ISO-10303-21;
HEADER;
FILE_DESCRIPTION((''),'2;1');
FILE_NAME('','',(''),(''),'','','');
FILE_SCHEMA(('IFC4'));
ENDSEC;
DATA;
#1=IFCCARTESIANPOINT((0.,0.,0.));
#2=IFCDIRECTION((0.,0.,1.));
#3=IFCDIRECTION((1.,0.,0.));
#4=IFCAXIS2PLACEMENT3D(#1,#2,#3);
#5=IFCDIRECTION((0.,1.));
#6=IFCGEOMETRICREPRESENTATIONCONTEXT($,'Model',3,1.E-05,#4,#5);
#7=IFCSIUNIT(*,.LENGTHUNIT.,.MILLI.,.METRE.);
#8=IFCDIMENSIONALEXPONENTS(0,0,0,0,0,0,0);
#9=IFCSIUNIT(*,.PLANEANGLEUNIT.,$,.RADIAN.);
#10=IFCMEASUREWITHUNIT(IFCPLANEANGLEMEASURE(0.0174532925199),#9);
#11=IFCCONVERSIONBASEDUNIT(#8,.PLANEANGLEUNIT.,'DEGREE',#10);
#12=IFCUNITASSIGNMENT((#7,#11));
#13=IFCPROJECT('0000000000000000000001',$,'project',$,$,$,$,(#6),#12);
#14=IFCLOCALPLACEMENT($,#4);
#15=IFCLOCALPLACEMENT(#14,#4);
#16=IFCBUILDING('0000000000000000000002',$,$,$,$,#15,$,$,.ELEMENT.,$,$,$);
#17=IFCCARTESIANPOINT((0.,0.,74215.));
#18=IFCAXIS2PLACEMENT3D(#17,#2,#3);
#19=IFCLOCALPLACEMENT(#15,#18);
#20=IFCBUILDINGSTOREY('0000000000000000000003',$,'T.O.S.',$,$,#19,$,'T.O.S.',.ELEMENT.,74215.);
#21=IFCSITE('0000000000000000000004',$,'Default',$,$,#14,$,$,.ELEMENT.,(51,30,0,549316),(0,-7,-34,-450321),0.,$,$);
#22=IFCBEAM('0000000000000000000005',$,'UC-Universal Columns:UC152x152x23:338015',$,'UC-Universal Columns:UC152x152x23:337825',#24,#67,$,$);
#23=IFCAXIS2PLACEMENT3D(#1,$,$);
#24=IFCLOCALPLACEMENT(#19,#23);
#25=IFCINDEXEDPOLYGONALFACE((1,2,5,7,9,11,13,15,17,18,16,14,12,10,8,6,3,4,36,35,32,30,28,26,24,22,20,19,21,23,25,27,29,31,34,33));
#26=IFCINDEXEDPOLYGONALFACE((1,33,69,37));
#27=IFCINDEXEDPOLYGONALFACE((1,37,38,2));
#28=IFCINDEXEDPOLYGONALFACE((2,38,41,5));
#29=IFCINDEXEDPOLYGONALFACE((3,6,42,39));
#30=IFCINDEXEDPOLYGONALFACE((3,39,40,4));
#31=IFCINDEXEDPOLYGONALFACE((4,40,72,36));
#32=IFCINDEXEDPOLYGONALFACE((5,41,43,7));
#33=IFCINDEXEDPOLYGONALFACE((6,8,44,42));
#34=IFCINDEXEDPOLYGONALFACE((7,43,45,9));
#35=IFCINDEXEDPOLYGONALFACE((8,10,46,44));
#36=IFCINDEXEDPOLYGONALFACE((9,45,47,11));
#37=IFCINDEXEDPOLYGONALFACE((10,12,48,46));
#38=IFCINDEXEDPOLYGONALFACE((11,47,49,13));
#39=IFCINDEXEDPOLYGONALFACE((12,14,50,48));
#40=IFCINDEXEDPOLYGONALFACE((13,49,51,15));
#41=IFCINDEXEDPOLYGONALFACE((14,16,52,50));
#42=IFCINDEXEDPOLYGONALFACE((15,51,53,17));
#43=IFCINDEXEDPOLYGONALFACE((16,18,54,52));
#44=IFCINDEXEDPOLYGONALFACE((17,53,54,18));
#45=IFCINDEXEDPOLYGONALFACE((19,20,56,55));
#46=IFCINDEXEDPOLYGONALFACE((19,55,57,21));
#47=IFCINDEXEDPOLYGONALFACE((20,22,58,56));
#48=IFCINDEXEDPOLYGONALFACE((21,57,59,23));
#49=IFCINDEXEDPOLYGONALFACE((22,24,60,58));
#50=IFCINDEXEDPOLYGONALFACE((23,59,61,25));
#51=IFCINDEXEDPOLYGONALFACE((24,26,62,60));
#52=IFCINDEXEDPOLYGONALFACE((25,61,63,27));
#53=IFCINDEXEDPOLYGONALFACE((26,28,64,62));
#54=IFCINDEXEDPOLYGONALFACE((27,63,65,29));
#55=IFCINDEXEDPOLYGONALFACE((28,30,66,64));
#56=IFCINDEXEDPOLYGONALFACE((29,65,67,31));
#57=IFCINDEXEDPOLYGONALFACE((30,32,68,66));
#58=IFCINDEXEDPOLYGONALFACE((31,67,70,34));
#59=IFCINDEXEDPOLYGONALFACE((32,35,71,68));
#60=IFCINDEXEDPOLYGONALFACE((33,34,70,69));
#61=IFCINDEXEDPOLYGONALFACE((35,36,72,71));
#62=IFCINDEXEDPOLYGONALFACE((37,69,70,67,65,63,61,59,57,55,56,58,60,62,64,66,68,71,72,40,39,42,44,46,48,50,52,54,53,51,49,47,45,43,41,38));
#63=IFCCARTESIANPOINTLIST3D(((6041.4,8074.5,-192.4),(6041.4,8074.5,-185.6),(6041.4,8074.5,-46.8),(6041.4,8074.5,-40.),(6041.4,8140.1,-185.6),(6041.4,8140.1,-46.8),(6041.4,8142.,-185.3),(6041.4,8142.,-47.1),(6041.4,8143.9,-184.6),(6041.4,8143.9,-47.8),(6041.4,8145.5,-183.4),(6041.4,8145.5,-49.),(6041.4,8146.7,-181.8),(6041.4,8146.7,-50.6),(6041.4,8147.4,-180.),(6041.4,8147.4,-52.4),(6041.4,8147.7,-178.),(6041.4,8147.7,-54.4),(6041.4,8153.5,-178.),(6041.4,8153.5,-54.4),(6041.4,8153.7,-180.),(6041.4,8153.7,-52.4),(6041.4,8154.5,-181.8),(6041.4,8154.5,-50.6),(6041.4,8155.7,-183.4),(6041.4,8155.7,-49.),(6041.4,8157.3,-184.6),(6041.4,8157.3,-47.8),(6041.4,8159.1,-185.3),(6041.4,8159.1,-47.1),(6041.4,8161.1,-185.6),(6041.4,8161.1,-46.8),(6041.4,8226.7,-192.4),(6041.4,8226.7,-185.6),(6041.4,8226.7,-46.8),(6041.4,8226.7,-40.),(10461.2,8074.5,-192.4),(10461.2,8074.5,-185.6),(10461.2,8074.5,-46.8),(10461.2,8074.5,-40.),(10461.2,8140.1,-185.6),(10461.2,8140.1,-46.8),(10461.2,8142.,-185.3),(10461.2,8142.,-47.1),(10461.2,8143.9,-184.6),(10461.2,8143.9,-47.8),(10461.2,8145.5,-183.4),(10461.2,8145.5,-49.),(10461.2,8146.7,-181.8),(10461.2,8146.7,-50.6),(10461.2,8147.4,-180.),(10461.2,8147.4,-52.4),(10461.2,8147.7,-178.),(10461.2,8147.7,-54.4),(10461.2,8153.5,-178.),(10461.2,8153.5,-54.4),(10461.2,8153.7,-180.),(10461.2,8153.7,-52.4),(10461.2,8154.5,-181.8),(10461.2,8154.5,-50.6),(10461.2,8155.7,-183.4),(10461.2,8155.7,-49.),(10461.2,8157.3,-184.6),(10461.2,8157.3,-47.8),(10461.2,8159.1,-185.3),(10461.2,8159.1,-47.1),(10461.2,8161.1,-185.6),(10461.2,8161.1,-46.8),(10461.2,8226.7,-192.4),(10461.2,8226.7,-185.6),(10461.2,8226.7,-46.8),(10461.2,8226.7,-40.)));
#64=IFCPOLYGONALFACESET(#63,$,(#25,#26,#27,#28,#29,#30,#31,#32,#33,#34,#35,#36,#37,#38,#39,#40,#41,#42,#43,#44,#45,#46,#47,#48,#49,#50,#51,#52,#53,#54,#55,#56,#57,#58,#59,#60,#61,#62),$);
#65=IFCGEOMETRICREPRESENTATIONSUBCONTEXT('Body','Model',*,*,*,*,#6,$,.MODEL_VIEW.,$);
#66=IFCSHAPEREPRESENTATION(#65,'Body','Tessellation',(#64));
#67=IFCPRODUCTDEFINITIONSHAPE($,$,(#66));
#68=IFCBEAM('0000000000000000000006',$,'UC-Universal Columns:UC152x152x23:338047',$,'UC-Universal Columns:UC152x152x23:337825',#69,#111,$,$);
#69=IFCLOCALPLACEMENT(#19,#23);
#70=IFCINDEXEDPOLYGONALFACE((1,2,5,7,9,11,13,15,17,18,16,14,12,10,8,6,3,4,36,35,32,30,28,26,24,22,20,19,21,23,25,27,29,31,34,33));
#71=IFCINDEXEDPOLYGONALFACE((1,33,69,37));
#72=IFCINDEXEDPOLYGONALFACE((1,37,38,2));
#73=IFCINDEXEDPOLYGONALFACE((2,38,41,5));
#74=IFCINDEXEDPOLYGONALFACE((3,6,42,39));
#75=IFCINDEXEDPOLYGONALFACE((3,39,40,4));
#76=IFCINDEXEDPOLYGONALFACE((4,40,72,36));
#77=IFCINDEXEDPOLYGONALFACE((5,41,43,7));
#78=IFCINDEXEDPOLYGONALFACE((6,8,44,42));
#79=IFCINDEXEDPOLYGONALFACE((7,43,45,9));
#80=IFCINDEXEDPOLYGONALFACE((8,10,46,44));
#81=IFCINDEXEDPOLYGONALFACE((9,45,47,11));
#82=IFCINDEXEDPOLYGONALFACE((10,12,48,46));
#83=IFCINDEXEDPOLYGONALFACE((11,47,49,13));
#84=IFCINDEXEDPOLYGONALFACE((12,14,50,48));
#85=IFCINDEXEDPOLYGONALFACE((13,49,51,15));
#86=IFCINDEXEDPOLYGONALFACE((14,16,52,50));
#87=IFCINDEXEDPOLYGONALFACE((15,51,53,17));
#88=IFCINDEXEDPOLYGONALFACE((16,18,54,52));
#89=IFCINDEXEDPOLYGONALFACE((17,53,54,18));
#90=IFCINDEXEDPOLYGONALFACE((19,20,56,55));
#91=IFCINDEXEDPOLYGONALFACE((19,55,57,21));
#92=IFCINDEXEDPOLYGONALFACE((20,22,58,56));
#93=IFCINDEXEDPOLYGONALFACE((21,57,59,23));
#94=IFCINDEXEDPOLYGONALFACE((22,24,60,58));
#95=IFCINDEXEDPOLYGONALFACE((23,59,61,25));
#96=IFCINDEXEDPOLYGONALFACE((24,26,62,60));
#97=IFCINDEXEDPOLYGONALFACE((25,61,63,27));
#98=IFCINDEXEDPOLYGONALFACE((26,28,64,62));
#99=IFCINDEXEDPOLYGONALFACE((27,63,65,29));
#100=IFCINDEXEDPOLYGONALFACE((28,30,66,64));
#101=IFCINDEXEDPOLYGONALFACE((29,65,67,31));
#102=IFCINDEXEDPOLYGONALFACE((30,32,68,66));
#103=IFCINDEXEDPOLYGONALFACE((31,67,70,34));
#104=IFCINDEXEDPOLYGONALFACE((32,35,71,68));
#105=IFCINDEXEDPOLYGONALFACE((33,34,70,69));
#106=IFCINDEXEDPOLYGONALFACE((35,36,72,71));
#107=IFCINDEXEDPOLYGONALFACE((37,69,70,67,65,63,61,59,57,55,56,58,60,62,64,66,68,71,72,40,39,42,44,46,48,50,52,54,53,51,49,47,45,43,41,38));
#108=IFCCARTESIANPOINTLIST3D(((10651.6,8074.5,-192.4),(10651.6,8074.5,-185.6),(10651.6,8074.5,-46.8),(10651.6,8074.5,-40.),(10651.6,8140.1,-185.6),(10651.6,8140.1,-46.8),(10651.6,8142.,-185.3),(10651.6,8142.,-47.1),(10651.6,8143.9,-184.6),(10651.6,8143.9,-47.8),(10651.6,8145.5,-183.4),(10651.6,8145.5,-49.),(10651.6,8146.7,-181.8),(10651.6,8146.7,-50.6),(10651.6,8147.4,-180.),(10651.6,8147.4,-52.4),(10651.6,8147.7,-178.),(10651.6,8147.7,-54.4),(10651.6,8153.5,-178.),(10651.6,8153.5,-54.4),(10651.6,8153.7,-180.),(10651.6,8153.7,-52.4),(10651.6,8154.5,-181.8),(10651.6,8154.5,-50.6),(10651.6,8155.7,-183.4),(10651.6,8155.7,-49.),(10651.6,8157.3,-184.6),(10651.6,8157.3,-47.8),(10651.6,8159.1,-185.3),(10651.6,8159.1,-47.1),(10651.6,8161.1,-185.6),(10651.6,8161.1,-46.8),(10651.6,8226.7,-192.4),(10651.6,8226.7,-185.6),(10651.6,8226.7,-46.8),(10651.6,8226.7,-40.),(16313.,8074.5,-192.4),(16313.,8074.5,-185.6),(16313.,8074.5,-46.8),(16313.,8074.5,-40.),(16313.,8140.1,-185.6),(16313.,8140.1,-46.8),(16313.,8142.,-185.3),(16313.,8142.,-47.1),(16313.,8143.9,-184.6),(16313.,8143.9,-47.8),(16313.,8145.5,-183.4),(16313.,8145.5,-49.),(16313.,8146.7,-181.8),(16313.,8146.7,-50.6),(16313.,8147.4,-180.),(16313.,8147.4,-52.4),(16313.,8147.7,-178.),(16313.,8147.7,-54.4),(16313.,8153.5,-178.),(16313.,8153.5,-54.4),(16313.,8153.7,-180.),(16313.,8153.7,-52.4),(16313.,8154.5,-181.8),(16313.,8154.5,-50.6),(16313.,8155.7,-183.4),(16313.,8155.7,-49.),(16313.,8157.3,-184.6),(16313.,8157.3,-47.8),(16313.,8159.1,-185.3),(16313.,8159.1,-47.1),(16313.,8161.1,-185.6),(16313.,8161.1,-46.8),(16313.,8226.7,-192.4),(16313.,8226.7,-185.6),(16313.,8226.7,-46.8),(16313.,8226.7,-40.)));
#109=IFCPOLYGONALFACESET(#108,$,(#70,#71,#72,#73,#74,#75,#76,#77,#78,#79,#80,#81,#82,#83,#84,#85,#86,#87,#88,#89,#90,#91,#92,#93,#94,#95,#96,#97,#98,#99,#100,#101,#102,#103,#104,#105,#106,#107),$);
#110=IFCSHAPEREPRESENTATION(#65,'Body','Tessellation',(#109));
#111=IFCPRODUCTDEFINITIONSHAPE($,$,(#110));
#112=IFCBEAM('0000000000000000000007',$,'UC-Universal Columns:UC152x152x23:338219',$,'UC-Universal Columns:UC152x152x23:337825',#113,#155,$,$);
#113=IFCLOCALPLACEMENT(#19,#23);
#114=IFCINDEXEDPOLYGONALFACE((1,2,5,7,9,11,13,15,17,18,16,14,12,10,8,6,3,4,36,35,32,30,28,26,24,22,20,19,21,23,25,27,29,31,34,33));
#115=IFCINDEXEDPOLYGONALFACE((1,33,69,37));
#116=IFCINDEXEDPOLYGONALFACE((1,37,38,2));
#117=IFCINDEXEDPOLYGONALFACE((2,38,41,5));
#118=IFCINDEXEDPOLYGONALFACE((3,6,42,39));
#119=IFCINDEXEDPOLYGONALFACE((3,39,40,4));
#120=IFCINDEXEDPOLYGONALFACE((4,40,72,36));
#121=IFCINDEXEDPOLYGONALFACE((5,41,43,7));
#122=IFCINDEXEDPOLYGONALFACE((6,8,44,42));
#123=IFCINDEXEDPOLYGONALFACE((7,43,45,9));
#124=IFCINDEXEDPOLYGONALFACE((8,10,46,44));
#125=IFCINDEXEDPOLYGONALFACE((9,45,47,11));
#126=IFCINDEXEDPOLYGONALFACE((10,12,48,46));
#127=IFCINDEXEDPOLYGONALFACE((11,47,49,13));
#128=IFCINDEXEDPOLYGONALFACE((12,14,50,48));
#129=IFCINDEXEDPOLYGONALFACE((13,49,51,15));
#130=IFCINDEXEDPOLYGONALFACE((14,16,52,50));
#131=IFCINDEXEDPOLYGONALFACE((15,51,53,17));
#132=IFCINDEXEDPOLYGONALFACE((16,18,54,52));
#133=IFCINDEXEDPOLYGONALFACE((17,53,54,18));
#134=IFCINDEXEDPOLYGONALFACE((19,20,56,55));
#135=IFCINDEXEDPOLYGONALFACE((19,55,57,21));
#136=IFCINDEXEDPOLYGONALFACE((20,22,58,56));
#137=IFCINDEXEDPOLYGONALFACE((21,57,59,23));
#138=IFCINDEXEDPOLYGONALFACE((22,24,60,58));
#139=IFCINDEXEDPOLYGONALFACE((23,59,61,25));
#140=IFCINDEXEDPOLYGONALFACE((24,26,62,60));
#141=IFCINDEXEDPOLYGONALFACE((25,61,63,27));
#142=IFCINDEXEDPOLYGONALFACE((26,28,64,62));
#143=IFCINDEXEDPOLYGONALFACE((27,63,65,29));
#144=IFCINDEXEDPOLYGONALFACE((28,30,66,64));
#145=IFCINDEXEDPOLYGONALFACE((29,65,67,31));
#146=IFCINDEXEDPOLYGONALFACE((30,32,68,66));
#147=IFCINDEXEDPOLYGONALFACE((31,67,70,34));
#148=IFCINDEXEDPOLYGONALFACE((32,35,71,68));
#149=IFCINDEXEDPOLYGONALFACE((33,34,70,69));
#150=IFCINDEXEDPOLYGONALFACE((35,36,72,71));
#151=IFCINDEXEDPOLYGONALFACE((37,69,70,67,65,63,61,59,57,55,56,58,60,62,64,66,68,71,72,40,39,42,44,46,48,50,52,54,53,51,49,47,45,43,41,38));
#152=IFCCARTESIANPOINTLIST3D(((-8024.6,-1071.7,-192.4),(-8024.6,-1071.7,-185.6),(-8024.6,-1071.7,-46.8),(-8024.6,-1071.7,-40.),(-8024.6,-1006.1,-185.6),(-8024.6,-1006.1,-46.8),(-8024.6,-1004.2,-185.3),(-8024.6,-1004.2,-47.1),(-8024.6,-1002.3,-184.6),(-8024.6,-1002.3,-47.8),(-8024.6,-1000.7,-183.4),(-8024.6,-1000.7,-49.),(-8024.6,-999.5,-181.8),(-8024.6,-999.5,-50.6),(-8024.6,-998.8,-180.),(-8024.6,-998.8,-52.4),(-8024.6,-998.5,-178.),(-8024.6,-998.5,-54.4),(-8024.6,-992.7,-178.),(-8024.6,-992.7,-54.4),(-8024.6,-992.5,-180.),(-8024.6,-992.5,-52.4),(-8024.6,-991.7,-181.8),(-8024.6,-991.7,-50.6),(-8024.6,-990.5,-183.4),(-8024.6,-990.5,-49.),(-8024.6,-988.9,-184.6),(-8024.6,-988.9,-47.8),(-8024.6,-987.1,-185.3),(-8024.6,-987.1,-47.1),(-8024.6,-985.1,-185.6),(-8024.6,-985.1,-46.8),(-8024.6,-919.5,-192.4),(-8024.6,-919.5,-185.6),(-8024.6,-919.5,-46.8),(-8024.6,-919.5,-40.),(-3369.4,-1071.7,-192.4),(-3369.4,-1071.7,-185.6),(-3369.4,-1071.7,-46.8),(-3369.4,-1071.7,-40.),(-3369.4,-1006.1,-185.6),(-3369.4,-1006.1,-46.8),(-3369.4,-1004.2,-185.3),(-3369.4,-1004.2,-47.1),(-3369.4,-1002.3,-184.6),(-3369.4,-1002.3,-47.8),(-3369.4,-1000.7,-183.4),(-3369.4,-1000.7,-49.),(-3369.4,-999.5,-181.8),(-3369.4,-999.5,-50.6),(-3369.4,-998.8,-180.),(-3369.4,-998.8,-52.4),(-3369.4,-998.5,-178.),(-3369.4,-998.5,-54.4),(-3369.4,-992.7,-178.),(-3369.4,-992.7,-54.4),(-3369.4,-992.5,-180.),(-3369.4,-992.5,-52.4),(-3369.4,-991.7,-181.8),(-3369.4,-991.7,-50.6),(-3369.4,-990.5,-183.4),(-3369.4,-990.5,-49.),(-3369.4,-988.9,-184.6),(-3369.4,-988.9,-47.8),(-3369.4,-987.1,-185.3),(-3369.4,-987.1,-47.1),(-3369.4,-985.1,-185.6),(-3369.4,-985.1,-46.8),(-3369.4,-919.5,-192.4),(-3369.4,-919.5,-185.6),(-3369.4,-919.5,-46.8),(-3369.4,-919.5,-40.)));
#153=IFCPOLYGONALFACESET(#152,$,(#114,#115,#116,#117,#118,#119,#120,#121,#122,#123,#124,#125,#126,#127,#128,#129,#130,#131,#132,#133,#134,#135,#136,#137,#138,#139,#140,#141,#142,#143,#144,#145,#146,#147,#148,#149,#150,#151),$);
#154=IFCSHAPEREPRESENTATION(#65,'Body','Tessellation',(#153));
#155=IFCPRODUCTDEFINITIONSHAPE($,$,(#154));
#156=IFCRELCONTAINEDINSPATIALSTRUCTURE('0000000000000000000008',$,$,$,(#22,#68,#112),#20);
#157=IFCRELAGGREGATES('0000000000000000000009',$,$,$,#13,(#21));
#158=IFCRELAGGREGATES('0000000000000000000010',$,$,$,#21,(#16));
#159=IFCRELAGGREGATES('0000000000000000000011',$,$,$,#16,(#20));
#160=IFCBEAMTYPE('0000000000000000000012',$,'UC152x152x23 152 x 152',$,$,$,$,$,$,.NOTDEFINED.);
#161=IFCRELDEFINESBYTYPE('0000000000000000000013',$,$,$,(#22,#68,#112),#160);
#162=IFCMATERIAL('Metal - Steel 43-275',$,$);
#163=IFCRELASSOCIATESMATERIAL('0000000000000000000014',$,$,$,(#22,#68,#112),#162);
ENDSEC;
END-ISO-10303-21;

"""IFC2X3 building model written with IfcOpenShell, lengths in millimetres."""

from ifc_helpers import new_model, entity, si_unit, converted_unit, point, direction, frame, frame_2d, origin_with_axes, place, context, subcontext, project, spatial, polyline, circle_curve, parameter, trimmed, segment, composite_curve, outline, extrude, material, type_object, element, save


model = new_model("IFC2X3")

# Units and contexts
model_context = context("Model", 3, precision=1e-05, world=origin_with_axes(), true_north=direction((0.0, 1.0)))
body_context = subcontext(model_context, "Body", "Model", "MODEL_VIEW")
ifc_project = project(units=[si_unit("LENGTHUNIT", "METRE", prefix="MILLI"), converted_unit("PLANEANGLEUNIT", "DEGREE", entity("IfcPlaneAngleMeasure", 0.0174532925199), si_unit("PLANEANGLEUNIT", "RADIAN"), dimensions=[0, 0, 0, 0, 0, 0, 0])], contexts=[model_context])

# Site, building, storey
site_placement = place(None, origin_with_axes())
site = spatial("IfcSite", under=ifc_project, at=site_placement, Name="Default", CompositionType="ELEMENT", RefLatitude=(51, 30, 0, 549316), RefLongitude=(0, -7, -34, -450321), RefElevation=0.0)
building_placement = place(site_placement, origin_with_axes())
building = spatial("IfcBuilding", under=site, at=building_placement, CompositionType="ELEMENT")
storey_placement = place(building_placement, frame((0.0, 0.0, 74215.0), z_axis=(0.0, 0.0, 1.0), x_axis=(1.0, 0.0, 0.0)))
storey = spatial("IfcBuildingStorey", under=building, at=storey_placement, Name="T.O.S.", LongName="T.O.S.", CompositionType="ELEMENT", Elevation=74215.0)

# Beams
ifc_material = material(Name="Metal - Steel 43-275")
beam_type_1 = type_object("IfcBeamType", Name="UC152x152x23 152 x 152", PredefinedType="NOTDEFINED")
beam_1_placement = place(storey_placement, frame((10461.2, 8150.6, -116.2), z_axis=(0.0, 0.0, 1.0), x_axis=(0.0, 1.0, 0.0)))
element("IfcBeam", 1, at=beam_1_placement, inside=storey, type_object=beam_type_1, material=ifc_material, Name="UC-Universal Columns:UC152x152x23:338015", ObjectType="UC-Universal Columns:UC152x152x23:337825", context=body_context, shape_type="SweptSolid", body=[
    extrude(outline(composite_curve([segment(polyline([(76.2, 76.1), (69.4, 76.1), (69.4, 10.5)]), True, "CONTINUOUS"), segment(trimmed(circle_curve(frame_2d((61.8, 10.5), x_axis=(0.0, -1.0)), 7.6), [point((69.4, 10.5)), parameter(90.0)], [point((61.8, 2.9)), parameter(0.0)], False, "CARTESIAN"), True, "CONTINUOUS"), segment(polyline([(61.8, 2.9), (-61.8, 2.9)]), True, "CONTINUOUS"), segment(trimmed(circle_curve(frame_2d((-61.8, 10.5), x_axis=(-1.0, 0.0)), 7.6), [point((-61.8, 2.9)), parameter(90.0)], [point((-69.4, 10.5)), parameter(0.0)], False, "CARTESIAN"), True, "CONTINUOUS"), segment(polyline([(-69.4, 10.5), (-69.4, 76.1), (-76.2, 76.1), (-76.2, -76.1), (-69.4, -76.1), (-69.4, -10.5)]), True, "CONTINUOUS"), segment(trimmed(circle_curve(frame_2d((-61.8, -10.5), x_axis=(0.0, 1.0)), 7.6), [point((-69.4, -10.5)), parameter(90.0)], [point((-61.8, -2.9)), parameter(0.0)], False, "CARTESIAN"), True, "CONTINUOUS"), segment(polyline([(-61.8, -2.9), (61.8, -2.9)]), True, "CONTINUOUS"), segment(trimmed(circle_curve(frame_2d((61.8, -10.5), x_axis=(1.0, 0.0)), 7.6), [point((61.8, -2.9)), parameter(90.0)], [point((69.4, -10.5)), parameter(0.0)], False, "CARTESIAN"), True, "CONTINUOUS"), segment(polyline([(69.4, -10.5), (69.4, -76.1), (76.2, -76.1), (76.2, 76.1)]), True, "CONTINUOUS")], self_intersect=False)), frame((0.0, 4419.8, 0.0), z_axis=(0.0, -1.0, 0.0), x_axis=(0.0, 0.0, -1.0)), (0.0, 0.0, 1.0), 4419.8),
])
beam_2_placement = place(storey_placement, frame((16313.0, 8150.6, -116.2), z_axis=(0.0, 0.0, 1.0), x_axis=(0.0, 1.0, 0.0)))
element("IfcBeam", 2, at=beam_2_placement, inside=storey, type_object=beam_type_1, material=ifc_material, Name="UC-Universal Columns:UC152x152x23:338047", ObjectType="UC-Universal Columns:UC152x152x23:337825", context=body_context, shape_type="SweptSolid", body=[
    extrude(outline(composite_curve([segment(polyline([(76.2, 76.1), (69.4, 76.1), (69.4, 10.5)]), True, "CONTINUOUS"), segment(trimmed(circle_curve(frame_2d((61.8, 10.5), x_axis=(0.0, -1.0)), 7.6), [point((69.4, 10.5)), parameter(90.0)], [point((61.8, 2.9)), parameter(0.0)], False, "CARTESIAN"), True, "CONTINUOUS"), segment(polyline([(61.8, 2.9), (-61.8, 2.9)]), True, "CONTINUOUS"), segment(trimmed(circle_curve(frame_2d((-61.8, 10.5), x_axis=(-1.0, 0.0)), 7.6), [point((-61.8, 2.9)), parameter(90.0)], [point((-69.4, 10.5)), parameter(0.0)], False, "CARTESIAN"), True, "CONTINUOUS"), segment(polyline([(-69.4, 10.5), (-69.4, 76.1), (-76.2, 76.1), (-76.2, -76.1), (-69.4, -76.1), (-69.4, -10.5)]), True, "CONTINUOUS"), segment(trimmed(circle_curve(frame_2d((-61.8, -10.5), x_axis=(0.0, 1.0)), 7.6), [point((-69.4, -10.5)), parameter(90.0)], [point((-61.8, -2.9)), parameter(0.0)], False, "CARTESIAN"), True, "CONTINUOUS"), segment(polyline([(-61.8, -2.9), (61.8, -2.9)]), True, "CONTINUOUS"), segment(trimmed(circle_curve(frame_2d((61.8, -10.5), x_axis=(1.0, 0.0)), 7.6), [point((61.8, -2.9)), parameter(90.0)], [point((69.4, -10.5)), parameter(0.0)], False, "CARTESIAN"), True, "CONTINUOUS"), segment(polyline([(69.4, -10.5), (69.4, -76.1), (76.2, -76.1), (76.2, 76.1)]), True, "CONTINUOUS")], self_intersect=False)), frame((0.0, 5661.4, 0.0), z_axis=(0.0, -1.0, 0.0), x_axis=(0.0, 0.0, -1.0)), (0.0, 0.0, 1.0), 5661.4),
])
beam_3_placement = place(storey_placement, frame((-3369.4, -995.6, -116.2), z_axis=(0.0, 0.0, 1.0), x_axis=(0.0, 1.0, 0.0)))
element("IfcBeam", 3, at=beam_3_placement, inside=storey, type_object=beam_type_1, material=ifc_material, Name="UC-Universal Columns:UC152x152x23:338219", ObjectType="UC-Universal Columns:UC152x152x23:337825", context=body_context, shape_type="SweptSolid", body=[
    extrude(outline(composite_curve([segment(polyline([(76.2, 76.1), (69.4, 76.1), (69.4, 10.5)]), True, "CONTINUOUS"), segment(trimmed(circle_curve(frame_2d((61.8, 10.5), x_axis=(0.0, -1.0)), 7.6), [point((69.4, 10.5)), parameter(90.0)], [point((61.8, 2.9)), parameter(0.0)], False, "CARTESIAN"), True, "CONTINUOUS"), segment(polyline([(61.8, 2.9), (-61.8, 2.9)]), True, "CONTINUOUS"), segment(trimmed(circle_curve(frame_2d((-61.8, 10.5), x_axis=(-1.0, 0.0)), 7.6), [point((-61.8, 2.9)), parameter(90.0)], [point((-69.4, 10.5)), parameter(0.0)], False, "CARTESIAN"), True, "CONTINUOUS"), segment(polyline([(-69.4, 10.5), (-69.4, 76.1), (-76.2, 76.1), (-76.2, -76.1), (-69.4, -76.1), (-69.4, -10.5)]), True, "CONTINUOUS"), segment(trimmed(circle_curve(frame_2d((-61.8, -10.5), x_axis=(0.0, 1.0)), 7.6), [point((-69.4, -10.5)), parameter(90.0)], [point((-61.8, -2.9)), parameter(0.0)], False, "CARTESIAN"), True, "CONTINUOUS"), segment(polyline([(-61.8, -2.9), (61.8, -2.9)]), True, "CONTINUOUS"), segment(trimmed(circle_curve(frame_2d((61.8, -10.5), x_axis=(1.0, 0.0)), 7.6), [point((61.8, -2.9)), parameter(90.0)], [point((69.4, -10.5)), parameter(0.0)], False, "CARTESIAN"), True, "CONTINUOUS"), segment(polyline([(69.4, -10.5), (69.4, -76.1), (76.2, -76.1), (76.2, 76.1)]), True, "CONTINUOUS")], self_intersect=False)), frame((0.0, 4655.2, 0.0), z_axis=(0.0, -1.0, 0.0), x_axis=(0.0, 0.0, -1.0)), (0.0, 0.0, 1.0), 4655.2),
])

save(model, "model.ifc")
